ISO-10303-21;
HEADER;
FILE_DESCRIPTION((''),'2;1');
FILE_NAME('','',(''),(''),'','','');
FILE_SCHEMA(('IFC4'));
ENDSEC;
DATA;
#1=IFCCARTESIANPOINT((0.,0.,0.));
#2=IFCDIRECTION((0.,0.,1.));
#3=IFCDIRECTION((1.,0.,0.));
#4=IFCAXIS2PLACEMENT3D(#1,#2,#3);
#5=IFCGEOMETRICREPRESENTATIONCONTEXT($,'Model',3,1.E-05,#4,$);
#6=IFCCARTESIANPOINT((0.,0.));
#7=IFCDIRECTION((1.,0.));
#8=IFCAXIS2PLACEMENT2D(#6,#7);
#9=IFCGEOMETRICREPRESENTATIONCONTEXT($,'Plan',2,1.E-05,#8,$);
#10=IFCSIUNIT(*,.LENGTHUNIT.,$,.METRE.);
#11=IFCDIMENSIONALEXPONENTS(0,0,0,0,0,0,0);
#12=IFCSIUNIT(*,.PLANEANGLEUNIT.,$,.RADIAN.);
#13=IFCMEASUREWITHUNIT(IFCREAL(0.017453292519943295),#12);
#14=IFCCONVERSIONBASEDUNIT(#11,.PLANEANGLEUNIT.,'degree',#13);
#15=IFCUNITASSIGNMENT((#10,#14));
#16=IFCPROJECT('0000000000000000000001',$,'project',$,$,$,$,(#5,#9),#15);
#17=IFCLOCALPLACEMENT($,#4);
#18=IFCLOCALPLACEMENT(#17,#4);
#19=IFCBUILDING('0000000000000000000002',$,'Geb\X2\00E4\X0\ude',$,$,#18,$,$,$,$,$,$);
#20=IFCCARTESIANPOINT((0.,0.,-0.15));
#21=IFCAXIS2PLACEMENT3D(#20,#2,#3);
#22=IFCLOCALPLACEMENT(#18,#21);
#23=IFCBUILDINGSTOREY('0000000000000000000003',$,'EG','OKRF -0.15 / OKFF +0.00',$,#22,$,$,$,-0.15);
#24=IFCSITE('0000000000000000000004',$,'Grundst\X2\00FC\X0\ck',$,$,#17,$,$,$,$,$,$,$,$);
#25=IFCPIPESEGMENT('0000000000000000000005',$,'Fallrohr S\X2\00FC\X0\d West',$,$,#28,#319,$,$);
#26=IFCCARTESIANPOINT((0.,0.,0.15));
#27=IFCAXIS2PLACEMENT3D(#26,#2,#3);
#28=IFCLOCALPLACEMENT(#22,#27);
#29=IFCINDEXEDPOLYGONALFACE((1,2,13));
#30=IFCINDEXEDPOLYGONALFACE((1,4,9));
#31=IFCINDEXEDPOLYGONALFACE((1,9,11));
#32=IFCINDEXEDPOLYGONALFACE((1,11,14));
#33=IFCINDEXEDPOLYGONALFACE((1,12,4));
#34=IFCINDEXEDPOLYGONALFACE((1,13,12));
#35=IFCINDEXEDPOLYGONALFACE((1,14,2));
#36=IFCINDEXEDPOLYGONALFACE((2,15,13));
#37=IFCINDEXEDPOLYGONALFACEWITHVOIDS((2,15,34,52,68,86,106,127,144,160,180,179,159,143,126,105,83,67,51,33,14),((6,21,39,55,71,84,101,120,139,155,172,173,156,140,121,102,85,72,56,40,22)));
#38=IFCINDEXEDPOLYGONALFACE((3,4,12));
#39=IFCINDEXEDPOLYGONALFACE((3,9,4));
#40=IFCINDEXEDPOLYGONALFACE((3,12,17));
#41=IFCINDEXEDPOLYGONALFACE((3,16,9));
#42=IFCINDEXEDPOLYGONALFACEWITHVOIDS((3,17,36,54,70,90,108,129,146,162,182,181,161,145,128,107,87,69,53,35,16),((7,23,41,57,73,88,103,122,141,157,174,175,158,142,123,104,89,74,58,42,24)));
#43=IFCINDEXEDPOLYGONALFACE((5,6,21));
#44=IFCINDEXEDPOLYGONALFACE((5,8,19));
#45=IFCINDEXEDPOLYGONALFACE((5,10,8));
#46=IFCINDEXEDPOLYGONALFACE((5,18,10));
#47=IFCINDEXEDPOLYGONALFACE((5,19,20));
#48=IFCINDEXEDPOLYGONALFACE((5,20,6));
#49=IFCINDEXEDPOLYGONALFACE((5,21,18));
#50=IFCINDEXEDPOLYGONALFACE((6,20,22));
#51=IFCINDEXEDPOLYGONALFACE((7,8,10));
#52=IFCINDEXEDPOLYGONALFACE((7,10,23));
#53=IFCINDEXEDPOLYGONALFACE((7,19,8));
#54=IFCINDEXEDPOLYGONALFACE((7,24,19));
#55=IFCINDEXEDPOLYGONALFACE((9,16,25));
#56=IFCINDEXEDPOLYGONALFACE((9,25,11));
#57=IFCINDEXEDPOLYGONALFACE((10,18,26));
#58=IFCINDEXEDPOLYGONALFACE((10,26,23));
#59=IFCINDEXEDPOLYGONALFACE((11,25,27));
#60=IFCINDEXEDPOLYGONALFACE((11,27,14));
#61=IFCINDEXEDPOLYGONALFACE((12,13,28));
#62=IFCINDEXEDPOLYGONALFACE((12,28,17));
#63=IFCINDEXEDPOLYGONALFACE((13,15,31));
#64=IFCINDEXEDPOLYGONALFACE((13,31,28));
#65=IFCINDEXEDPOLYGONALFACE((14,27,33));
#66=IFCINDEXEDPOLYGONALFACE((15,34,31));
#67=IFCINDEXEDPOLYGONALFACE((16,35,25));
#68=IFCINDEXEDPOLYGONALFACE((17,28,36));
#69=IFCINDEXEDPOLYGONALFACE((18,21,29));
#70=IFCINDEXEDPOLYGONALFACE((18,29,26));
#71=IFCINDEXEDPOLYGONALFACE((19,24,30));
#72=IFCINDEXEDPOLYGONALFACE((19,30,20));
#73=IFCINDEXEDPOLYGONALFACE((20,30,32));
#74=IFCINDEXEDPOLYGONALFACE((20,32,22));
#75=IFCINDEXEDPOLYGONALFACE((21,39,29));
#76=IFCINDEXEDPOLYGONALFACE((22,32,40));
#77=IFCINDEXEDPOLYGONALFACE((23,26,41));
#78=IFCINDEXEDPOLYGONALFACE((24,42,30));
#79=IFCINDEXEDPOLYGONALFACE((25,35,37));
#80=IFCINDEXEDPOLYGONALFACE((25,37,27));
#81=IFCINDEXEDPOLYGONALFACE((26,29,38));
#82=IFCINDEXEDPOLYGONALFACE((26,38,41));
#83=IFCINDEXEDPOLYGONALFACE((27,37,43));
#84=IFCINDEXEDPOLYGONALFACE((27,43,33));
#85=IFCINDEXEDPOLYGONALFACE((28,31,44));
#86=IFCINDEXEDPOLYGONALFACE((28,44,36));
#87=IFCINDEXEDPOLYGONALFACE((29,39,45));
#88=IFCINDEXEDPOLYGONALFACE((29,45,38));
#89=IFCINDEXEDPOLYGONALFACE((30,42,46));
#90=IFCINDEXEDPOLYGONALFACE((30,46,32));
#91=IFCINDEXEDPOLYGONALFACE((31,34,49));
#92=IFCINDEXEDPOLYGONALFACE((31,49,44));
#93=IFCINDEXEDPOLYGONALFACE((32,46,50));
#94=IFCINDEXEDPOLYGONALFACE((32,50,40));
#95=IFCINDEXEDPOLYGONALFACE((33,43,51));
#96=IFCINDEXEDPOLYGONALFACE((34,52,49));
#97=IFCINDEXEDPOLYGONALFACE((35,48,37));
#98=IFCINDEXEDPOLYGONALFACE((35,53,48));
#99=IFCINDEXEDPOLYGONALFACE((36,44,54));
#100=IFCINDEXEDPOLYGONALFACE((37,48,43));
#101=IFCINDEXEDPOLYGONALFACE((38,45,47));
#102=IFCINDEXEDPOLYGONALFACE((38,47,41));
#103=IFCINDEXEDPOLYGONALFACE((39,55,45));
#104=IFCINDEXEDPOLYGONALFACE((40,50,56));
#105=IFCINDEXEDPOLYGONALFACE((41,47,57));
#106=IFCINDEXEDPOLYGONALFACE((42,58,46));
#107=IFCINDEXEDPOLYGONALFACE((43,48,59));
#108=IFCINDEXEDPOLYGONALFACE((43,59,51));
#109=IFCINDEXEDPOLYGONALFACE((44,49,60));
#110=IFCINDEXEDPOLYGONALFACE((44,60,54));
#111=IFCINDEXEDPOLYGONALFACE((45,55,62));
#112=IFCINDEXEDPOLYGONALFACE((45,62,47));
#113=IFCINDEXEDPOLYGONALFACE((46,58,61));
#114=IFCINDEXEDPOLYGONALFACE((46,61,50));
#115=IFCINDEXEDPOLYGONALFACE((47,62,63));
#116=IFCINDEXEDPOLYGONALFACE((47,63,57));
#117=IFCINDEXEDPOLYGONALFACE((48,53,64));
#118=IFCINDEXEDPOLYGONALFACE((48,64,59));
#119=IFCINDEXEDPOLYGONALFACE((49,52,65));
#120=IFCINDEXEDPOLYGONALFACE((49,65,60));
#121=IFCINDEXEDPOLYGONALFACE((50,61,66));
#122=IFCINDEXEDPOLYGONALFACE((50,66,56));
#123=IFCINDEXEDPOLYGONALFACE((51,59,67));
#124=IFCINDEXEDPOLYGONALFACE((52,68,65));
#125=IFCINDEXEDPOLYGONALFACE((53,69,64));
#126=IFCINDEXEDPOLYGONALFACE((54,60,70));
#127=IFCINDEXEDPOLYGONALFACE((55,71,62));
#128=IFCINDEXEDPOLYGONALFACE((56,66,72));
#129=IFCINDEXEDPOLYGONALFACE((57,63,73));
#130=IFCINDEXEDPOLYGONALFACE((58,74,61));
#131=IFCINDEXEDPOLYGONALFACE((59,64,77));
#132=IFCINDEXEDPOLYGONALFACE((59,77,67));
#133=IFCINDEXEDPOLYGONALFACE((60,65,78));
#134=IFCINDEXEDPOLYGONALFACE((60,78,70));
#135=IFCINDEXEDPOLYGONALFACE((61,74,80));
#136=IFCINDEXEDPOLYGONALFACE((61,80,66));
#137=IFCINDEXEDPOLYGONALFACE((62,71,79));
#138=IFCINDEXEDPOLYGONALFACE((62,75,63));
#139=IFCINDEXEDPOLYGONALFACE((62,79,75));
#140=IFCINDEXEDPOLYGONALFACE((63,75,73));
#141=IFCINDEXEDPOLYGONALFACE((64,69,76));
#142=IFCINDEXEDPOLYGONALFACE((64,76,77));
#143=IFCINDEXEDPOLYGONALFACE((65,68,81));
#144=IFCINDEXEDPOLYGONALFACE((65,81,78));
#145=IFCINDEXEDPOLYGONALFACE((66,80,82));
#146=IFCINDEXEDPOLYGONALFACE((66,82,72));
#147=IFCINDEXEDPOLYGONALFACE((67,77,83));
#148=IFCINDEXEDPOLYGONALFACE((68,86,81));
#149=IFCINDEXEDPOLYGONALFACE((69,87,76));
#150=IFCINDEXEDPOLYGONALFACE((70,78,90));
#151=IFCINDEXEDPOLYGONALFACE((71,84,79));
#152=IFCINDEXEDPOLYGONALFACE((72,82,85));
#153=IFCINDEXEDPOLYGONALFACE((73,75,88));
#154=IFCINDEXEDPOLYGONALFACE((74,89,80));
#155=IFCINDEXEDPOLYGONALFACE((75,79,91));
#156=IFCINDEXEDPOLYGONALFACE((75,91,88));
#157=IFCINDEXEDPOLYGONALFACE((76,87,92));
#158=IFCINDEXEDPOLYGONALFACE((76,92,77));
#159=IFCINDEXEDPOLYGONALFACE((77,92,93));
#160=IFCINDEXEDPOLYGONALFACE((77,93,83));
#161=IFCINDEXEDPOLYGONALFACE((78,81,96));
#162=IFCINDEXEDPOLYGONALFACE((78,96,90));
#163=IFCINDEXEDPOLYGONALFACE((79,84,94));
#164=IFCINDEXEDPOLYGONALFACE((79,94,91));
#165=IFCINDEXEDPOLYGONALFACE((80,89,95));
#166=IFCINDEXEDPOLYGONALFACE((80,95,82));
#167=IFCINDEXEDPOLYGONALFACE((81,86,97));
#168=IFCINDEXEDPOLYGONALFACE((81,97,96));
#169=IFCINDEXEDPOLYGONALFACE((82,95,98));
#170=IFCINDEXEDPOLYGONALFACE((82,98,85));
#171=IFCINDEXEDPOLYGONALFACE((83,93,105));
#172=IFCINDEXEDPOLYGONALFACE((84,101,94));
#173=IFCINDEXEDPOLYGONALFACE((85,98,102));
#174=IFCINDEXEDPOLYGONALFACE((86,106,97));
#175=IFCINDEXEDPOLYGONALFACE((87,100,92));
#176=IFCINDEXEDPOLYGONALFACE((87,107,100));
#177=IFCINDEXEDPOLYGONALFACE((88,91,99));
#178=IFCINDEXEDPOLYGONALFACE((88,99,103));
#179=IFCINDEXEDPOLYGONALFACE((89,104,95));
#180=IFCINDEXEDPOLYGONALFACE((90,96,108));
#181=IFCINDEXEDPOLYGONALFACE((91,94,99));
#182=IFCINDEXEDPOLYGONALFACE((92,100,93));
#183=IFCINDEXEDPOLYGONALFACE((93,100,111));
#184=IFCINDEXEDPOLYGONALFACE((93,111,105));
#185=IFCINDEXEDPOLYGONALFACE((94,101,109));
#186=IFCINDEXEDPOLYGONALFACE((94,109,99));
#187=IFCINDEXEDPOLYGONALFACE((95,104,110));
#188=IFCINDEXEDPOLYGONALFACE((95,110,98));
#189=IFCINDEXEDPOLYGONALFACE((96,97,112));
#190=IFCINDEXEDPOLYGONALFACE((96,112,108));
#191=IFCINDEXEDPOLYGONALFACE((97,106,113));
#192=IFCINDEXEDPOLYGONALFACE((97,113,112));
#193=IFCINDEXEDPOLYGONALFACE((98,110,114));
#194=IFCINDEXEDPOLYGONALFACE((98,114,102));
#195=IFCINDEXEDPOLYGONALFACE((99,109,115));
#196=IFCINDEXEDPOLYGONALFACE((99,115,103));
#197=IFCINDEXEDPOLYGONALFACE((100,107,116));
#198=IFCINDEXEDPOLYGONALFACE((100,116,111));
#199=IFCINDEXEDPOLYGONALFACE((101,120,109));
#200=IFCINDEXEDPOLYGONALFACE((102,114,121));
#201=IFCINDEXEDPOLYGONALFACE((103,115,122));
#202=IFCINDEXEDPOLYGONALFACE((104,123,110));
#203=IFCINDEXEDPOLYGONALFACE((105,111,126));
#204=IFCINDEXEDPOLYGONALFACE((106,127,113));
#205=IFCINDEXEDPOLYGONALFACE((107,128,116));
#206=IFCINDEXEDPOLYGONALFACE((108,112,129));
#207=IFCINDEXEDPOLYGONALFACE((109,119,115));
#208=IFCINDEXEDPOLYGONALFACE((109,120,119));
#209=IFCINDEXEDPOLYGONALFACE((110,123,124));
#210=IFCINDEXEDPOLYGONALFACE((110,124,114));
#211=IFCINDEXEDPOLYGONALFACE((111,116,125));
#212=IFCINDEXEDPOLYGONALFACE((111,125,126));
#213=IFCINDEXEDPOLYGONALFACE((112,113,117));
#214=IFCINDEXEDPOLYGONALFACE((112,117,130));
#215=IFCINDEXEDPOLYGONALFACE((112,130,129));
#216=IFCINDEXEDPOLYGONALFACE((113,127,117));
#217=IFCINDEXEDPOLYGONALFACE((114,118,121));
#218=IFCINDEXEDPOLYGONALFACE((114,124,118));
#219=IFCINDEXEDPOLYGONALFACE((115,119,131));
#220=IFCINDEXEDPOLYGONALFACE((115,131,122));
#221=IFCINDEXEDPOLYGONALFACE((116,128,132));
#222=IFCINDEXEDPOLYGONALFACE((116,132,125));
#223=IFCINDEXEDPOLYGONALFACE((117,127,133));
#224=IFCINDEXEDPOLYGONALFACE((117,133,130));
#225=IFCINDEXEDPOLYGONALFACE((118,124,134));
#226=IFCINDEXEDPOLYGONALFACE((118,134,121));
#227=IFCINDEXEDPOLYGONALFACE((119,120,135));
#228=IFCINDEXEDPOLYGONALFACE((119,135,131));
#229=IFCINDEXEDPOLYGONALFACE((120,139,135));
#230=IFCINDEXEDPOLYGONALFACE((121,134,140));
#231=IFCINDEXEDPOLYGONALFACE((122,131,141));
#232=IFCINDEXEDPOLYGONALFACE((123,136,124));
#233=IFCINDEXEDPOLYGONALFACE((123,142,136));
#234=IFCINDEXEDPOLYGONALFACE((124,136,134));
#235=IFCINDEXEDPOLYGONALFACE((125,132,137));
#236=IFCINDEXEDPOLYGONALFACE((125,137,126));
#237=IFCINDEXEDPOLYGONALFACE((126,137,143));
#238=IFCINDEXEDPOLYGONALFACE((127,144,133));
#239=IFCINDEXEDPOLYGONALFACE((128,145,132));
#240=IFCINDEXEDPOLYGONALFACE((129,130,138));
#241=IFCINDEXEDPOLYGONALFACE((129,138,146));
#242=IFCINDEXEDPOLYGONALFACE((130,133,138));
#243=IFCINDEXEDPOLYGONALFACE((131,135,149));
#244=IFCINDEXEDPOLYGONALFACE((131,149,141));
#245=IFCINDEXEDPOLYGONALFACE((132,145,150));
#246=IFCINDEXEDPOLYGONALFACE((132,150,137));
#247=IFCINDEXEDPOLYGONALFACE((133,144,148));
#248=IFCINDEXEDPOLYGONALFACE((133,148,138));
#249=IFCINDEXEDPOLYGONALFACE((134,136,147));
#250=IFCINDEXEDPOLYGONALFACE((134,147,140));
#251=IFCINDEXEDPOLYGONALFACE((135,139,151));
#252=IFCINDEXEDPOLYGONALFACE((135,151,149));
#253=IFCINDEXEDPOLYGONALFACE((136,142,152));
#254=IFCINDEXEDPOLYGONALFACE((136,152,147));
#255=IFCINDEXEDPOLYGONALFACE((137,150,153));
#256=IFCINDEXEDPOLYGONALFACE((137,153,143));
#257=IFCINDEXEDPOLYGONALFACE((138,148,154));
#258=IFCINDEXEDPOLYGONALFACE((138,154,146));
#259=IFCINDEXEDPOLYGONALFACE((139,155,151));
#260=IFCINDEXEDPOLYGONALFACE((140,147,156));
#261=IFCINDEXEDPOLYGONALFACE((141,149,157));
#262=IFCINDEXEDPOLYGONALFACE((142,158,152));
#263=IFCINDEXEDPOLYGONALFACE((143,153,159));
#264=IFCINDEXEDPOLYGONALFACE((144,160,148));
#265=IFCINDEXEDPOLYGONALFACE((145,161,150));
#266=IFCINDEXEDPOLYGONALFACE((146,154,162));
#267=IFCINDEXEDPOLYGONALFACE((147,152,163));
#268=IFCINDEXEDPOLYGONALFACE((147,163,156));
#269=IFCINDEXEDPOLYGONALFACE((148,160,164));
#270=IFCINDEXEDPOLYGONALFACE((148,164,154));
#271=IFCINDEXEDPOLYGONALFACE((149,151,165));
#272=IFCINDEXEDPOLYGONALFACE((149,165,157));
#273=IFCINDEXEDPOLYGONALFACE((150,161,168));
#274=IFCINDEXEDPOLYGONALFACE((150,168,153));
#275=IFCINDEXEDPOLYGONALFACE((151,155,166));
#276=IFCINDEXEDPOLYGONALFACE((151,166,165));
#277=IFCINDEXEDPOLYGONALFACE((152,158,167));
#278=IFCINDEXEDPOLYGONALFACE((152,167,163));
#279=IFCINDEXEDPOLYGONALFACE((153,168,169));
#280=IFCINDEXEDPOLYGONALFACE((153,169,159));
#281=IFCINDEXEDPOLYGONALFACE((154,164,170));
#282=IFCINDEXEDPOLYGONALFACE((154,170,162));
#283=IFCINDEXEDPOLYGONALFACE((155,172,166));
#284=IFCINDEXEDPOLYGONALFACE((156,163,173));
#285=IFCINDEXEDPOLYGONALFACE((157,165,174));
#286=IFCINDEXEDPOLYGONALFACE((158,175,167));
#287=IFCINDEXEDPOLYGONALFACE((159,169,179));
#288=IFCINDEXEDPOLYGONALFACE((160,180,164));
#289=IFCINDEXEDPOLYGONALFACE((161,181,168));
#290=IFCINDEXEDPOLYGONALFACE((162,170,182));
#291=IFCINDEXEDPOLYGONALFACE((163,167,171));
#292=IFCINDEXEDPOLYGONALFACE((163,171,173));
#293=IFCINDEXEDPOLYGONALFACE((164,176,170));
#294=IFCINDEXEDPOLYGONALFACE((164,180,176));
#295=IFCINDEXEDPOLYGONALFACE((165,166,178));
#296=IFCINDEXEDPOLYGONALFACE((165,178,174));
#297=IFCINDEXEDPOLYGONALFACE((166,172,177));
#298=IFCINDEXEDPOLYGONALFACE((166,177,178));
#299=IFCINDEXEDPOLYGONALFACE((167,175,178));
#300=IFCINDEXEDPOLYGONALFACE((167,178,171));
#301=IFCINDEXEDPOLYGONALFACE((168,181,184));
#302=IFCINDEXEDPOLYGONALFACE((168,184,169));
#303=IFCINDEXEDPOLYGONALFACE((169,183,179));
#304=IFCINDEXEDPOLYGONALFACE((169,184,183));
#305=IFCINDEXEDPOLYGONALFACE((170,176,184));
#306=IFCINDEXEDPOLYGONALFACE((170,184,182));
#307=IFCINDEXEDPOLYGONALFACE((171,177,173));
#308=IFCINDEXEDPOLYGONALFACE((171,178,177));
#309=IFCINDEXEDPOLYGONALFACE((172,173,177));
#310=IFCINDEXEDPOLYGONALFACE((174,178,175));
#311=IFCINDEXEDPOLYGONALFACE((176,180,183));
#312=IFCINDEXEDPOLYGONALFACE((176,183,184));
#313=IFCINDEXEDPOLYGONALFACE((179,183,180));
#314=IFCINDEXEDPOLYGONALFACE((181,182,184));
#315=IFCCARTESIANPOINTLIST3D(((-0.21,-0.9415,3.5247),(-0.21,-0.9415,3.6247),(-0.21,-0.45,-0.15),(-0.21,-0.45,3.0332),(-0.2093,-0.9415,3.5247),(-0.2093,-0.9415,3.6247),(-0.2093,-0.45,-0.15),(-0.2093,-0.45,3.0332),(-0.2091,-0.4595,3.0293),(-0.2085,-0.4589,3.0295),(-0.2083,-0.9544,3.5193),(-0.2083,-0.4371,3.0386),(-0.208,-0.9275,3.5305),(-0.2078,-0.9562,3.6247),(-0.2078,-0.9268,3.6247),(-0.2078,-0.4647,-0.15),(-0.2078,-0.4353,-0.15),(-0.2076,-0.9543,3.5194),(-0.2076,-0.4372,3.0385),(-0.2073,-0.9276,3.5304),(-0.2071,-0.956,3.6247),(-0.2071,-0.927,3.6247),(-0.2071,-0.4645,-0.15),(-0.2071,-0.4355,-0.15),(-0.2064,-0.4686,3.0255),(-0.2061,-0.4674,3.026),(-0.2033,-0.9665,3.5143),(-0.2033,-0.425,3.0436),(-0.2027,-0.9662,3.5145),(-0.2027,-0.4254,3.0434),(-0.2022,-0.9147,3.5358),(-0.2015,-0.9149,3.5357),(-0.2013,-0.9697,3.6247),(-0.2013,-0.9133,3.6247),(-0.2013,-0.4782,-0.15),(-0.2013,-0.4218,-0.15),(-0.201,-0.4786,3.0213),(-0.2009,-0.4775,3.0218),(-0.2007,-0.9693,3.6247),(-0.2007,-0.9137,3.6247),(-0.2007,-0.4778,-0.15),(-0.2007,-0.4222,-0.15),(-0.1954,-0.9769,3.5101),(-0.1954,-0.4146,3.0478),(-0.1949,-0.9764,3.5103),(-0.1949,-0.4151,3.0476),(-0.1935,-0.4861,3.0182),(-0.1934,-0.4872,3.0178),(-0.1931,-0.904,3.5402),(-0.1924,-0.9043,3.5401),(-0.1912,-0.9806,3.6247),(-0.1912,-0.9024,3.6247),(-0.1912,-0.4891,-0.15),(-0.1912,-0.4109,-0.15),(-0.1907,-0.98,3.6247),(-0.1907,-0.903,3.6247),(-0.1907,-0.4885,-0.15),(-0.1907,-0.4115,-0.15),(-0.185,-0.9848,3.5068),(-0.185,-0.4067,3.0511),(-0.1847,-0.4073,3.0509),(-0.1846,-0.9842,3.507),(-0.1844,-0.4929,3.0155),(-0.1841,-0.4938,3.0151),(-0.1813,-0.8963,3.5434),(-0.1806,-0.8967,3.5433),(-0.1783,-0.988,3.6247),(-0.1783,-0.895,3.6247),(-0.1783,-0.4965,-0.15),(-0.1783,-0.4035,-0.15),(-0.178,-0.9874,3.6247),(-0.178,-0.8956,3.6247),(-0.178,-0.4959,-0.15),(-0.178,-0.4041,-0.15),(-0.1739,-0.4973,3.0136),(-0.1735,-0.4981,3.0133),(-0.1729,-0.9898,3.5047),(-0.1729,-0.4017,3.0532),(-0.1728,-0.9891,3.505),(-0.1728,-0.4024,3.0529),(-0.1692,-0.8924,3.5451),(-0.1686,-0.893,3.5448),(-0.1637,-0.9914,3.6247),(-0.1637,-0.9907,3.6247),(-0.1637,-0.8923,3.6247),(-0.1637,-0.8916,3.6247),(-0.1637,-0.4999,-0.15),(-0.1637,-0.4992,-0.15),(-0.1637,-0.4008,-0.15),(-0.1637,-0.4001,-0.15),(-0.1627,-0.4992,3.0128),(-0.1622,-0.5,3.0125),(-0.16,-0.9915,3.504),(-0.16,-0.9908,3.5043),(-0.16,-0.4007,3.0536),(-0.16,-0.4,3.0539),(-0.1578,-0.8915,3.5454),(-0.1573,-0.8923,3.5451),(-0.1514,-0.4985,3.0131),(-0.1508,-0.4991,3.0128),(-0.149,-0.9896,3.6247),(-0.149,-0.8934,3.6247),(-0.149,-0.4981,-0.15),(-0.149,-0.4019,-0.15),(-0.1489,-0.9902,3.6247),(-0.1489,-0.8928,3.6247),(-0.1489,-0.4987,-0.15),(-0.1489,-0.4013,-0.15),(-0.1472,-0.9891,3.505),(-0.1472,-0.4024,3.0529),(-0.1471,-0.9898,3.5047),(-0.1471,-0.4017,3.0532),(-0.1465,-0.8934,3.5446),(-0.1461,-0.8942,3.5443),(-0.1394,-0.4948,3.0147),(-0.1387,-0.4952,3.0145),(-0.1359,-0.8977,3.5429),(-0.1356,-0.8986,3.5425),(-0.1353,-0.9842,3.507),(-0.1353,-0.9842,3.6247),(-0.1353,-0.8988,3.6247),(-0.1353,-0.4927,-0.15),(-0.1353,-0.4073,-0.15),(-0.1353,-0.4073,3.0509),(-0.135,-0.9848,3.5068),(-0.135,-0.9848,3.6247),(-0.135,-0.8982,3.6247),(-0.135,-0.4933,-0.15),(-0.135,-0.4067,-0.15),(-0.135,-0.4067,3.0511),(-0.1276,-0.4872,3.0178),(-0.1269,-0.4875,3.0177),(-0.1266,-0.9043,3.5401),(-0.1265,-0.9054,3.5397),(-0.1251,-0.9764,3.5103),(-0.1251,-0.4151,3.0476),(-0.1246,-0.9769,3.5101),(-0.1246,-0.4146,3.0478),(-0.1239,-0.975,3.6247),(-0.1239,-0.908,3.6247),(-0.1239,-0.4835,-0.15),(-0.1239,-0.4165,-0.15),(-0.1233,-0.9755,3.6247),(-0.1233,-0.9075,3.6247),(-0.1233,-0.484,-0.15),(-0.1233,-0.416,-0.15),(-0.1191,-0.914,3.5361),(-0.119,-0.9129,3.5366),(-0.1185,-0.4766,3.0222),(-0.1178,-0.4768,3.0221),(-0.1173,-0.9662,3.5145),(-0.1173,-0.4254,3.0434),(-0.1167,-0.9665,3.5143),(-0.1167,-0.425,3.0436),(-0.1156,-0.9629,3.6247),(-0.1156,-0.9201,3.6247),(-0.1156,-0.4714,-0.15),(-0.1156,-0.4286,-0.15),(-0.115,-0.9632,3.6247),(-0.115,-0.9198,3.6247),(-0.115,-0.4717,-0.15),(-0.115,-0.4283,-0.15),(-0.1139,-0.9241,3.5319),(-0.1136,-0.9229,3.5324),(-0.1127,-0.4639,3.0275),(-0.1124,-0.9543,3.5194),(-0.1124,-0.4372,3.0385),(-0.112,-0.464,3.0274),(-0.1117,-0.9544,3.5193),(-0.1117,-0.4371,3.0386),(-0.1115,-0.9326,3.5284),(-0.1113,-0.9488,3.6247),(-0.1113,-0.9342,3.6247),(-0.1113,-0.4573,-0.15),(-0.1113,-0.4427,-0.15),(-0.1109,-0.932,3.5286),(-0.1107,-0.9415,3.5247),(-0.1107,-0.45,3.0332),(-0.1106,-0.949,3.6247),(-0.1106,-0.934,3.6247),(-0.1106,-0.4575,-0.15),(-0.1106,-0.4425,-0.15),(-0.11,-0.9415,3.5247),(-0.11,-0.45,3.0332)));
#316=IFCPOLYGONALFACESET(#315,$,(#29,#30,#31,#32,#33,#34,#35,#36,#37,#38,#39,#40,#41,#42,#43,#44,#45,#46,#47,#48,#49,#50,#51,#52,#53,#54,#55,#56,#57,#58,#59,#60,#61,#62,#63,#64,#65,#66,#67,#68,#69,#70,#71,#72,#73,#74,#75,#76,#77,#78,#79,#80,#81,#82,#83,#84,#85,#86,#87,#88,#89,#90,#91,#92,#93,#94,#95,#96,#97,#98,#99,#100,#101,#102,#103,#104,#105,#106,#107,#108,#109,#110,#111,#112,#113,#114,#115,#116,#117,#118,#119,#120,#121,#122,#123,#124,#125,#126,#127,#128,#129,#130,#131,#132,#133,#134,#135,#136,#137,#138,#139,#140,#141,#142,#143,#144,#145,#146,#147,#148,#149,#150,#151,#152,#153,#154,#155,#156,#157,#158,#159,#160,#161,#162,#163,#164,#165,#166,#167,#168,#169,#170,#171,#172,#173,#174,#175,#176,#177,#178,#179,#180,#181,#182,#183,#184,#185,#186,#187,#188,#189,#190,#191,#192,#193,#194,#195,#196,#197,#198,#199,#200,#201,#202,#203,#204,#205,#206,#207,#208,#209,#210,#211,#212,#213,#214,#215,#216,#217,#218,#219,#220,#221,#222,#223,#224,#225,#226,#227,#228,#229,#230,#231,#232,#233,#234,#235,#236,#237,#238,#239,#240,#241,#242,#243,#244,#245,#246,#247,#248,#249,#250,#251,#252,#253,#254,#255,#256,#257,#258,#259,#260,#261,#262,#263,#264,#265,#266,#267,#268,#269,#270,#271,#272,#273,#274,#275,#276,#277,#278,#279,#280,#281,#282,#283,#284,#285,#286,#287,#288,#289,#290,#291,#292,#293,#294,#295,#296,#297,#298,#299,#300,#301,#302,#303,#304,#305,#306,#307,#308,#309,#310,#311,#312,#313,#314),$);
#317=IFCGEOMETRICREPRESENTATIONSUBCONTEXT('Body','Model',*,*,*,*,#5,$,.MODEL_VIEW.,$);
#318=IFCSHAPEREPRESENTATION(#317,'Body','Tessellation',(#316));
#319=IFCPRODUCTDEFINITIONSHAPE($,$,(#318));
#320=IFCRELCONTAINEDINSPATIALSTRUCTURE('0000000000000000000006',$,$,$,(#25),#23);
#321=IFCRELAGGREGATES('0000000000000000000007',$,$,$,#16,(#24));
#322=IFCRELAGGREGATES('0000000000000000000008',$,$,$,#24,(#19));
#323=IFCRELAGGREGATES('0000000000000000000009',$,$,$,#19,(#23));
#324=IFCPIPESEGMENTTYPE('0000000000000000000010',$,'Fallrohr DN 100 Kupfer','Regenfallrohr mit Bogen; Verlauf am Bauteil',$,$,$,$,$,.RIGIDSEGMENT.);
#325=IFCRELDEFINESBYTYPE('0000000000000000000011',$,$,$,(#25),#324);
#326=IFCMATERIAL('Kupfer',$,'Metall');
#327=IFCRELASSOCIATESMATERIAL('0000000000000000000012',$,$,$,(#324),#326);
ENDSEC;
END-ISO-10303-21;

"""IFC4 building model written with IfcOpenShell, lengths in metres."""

from ifc_helpers import new_model, entity, si_unit, converted_unit, frame, origin_with_axes, origin_2d_with_axis, place, context, subcontext, project, spatial, material, type_object, element, save


model = new_model("IFC4")

# Units and contexts
model_context = context("Model", 3, precision=1e-05, world=origin_with_axes())
plan_context = context("Plan", 2, precision=1e-05, world=origin_2d_with_axis())
body_context = subcontext(model_context, "Body", "Model", "MODEL_VIEW")
ifc_project = project(units=[si_unit("LENGTHUNIT", "METRE"), converted_unit("PLANEANGLEUNIT", "degree", entity("IfcReal", 0.017453292519943295), si_unit("PLANEANGLEUNIT", "RADIAN"), dimensions=[0, 0, 0, 0, 0, 0, 0])], contexts=[model_context, plan_context])

# Site, building, storey
site_placement = place(None, origin_with_axes())
site = spatial("IfcSite", under=ifc_project, at=site_placement, Name="Grundstück")
building_placement = place(site_placement, origin_with_axes())
building = spatial("IfcBuilding", under=site, at=building_placement, Name="Gebäude")
storey_placement = place(building_placement, frame((0.0, 0.0, -0.15), z_axis=(0.0, 0.0, 1.0), x_axis=(1.0, 0.0, 0.0)))
storey = spatial("IfcBuildingStorey", under=building, at=storey_placement, Name="EG", Description="OKRF -0.15 / OKFF +0.00", Elevation=-0.15)

# Pipe segment
ifc_material_1 = material(Name="Kupfer", Category="Metall")
pipe_segment_type = type_object("IfcPipeSegmentType", Name="Fallrohr DN 100 Kupfer", Description="Regenfallrohr mit Bogen; Verlauf am Bauteil", PredefinedType="RIGIDSEGMENT", material=ifc_material_1)
pipe_segment_1_placement = place(storey_placement, frame((0.0, 0.0, 0.15), z_axis=(0.0, 0.0, 1.0), x_axis=(1.0, 0.0, 0.0)))
element("IfcPipeSegment", 1, at=pipe_segment_1_placement, inside=storey, type_object=pipe_segment_type, Name="Fallrohr Süd West", context=body_context, shape_type="AdvancedSweptSolid", body=[
    entity("IfcSweptDiskSolid", entity("IfcPolyline", [entity("IfcCartesianPoint", [-0.16, -0.9415, 3.6247]), entity("IfcCartesianPoint", [-0.16, -0.9415, 3.5247]), entity("IfcCartesianPoint", [-0.16, -0.45, 3.0332]), entity("IfcCartesianPoint", [-0.16, -0.45, -0.15])]), 0.05, 0.0493),
])

save(model, "model.ifc")
